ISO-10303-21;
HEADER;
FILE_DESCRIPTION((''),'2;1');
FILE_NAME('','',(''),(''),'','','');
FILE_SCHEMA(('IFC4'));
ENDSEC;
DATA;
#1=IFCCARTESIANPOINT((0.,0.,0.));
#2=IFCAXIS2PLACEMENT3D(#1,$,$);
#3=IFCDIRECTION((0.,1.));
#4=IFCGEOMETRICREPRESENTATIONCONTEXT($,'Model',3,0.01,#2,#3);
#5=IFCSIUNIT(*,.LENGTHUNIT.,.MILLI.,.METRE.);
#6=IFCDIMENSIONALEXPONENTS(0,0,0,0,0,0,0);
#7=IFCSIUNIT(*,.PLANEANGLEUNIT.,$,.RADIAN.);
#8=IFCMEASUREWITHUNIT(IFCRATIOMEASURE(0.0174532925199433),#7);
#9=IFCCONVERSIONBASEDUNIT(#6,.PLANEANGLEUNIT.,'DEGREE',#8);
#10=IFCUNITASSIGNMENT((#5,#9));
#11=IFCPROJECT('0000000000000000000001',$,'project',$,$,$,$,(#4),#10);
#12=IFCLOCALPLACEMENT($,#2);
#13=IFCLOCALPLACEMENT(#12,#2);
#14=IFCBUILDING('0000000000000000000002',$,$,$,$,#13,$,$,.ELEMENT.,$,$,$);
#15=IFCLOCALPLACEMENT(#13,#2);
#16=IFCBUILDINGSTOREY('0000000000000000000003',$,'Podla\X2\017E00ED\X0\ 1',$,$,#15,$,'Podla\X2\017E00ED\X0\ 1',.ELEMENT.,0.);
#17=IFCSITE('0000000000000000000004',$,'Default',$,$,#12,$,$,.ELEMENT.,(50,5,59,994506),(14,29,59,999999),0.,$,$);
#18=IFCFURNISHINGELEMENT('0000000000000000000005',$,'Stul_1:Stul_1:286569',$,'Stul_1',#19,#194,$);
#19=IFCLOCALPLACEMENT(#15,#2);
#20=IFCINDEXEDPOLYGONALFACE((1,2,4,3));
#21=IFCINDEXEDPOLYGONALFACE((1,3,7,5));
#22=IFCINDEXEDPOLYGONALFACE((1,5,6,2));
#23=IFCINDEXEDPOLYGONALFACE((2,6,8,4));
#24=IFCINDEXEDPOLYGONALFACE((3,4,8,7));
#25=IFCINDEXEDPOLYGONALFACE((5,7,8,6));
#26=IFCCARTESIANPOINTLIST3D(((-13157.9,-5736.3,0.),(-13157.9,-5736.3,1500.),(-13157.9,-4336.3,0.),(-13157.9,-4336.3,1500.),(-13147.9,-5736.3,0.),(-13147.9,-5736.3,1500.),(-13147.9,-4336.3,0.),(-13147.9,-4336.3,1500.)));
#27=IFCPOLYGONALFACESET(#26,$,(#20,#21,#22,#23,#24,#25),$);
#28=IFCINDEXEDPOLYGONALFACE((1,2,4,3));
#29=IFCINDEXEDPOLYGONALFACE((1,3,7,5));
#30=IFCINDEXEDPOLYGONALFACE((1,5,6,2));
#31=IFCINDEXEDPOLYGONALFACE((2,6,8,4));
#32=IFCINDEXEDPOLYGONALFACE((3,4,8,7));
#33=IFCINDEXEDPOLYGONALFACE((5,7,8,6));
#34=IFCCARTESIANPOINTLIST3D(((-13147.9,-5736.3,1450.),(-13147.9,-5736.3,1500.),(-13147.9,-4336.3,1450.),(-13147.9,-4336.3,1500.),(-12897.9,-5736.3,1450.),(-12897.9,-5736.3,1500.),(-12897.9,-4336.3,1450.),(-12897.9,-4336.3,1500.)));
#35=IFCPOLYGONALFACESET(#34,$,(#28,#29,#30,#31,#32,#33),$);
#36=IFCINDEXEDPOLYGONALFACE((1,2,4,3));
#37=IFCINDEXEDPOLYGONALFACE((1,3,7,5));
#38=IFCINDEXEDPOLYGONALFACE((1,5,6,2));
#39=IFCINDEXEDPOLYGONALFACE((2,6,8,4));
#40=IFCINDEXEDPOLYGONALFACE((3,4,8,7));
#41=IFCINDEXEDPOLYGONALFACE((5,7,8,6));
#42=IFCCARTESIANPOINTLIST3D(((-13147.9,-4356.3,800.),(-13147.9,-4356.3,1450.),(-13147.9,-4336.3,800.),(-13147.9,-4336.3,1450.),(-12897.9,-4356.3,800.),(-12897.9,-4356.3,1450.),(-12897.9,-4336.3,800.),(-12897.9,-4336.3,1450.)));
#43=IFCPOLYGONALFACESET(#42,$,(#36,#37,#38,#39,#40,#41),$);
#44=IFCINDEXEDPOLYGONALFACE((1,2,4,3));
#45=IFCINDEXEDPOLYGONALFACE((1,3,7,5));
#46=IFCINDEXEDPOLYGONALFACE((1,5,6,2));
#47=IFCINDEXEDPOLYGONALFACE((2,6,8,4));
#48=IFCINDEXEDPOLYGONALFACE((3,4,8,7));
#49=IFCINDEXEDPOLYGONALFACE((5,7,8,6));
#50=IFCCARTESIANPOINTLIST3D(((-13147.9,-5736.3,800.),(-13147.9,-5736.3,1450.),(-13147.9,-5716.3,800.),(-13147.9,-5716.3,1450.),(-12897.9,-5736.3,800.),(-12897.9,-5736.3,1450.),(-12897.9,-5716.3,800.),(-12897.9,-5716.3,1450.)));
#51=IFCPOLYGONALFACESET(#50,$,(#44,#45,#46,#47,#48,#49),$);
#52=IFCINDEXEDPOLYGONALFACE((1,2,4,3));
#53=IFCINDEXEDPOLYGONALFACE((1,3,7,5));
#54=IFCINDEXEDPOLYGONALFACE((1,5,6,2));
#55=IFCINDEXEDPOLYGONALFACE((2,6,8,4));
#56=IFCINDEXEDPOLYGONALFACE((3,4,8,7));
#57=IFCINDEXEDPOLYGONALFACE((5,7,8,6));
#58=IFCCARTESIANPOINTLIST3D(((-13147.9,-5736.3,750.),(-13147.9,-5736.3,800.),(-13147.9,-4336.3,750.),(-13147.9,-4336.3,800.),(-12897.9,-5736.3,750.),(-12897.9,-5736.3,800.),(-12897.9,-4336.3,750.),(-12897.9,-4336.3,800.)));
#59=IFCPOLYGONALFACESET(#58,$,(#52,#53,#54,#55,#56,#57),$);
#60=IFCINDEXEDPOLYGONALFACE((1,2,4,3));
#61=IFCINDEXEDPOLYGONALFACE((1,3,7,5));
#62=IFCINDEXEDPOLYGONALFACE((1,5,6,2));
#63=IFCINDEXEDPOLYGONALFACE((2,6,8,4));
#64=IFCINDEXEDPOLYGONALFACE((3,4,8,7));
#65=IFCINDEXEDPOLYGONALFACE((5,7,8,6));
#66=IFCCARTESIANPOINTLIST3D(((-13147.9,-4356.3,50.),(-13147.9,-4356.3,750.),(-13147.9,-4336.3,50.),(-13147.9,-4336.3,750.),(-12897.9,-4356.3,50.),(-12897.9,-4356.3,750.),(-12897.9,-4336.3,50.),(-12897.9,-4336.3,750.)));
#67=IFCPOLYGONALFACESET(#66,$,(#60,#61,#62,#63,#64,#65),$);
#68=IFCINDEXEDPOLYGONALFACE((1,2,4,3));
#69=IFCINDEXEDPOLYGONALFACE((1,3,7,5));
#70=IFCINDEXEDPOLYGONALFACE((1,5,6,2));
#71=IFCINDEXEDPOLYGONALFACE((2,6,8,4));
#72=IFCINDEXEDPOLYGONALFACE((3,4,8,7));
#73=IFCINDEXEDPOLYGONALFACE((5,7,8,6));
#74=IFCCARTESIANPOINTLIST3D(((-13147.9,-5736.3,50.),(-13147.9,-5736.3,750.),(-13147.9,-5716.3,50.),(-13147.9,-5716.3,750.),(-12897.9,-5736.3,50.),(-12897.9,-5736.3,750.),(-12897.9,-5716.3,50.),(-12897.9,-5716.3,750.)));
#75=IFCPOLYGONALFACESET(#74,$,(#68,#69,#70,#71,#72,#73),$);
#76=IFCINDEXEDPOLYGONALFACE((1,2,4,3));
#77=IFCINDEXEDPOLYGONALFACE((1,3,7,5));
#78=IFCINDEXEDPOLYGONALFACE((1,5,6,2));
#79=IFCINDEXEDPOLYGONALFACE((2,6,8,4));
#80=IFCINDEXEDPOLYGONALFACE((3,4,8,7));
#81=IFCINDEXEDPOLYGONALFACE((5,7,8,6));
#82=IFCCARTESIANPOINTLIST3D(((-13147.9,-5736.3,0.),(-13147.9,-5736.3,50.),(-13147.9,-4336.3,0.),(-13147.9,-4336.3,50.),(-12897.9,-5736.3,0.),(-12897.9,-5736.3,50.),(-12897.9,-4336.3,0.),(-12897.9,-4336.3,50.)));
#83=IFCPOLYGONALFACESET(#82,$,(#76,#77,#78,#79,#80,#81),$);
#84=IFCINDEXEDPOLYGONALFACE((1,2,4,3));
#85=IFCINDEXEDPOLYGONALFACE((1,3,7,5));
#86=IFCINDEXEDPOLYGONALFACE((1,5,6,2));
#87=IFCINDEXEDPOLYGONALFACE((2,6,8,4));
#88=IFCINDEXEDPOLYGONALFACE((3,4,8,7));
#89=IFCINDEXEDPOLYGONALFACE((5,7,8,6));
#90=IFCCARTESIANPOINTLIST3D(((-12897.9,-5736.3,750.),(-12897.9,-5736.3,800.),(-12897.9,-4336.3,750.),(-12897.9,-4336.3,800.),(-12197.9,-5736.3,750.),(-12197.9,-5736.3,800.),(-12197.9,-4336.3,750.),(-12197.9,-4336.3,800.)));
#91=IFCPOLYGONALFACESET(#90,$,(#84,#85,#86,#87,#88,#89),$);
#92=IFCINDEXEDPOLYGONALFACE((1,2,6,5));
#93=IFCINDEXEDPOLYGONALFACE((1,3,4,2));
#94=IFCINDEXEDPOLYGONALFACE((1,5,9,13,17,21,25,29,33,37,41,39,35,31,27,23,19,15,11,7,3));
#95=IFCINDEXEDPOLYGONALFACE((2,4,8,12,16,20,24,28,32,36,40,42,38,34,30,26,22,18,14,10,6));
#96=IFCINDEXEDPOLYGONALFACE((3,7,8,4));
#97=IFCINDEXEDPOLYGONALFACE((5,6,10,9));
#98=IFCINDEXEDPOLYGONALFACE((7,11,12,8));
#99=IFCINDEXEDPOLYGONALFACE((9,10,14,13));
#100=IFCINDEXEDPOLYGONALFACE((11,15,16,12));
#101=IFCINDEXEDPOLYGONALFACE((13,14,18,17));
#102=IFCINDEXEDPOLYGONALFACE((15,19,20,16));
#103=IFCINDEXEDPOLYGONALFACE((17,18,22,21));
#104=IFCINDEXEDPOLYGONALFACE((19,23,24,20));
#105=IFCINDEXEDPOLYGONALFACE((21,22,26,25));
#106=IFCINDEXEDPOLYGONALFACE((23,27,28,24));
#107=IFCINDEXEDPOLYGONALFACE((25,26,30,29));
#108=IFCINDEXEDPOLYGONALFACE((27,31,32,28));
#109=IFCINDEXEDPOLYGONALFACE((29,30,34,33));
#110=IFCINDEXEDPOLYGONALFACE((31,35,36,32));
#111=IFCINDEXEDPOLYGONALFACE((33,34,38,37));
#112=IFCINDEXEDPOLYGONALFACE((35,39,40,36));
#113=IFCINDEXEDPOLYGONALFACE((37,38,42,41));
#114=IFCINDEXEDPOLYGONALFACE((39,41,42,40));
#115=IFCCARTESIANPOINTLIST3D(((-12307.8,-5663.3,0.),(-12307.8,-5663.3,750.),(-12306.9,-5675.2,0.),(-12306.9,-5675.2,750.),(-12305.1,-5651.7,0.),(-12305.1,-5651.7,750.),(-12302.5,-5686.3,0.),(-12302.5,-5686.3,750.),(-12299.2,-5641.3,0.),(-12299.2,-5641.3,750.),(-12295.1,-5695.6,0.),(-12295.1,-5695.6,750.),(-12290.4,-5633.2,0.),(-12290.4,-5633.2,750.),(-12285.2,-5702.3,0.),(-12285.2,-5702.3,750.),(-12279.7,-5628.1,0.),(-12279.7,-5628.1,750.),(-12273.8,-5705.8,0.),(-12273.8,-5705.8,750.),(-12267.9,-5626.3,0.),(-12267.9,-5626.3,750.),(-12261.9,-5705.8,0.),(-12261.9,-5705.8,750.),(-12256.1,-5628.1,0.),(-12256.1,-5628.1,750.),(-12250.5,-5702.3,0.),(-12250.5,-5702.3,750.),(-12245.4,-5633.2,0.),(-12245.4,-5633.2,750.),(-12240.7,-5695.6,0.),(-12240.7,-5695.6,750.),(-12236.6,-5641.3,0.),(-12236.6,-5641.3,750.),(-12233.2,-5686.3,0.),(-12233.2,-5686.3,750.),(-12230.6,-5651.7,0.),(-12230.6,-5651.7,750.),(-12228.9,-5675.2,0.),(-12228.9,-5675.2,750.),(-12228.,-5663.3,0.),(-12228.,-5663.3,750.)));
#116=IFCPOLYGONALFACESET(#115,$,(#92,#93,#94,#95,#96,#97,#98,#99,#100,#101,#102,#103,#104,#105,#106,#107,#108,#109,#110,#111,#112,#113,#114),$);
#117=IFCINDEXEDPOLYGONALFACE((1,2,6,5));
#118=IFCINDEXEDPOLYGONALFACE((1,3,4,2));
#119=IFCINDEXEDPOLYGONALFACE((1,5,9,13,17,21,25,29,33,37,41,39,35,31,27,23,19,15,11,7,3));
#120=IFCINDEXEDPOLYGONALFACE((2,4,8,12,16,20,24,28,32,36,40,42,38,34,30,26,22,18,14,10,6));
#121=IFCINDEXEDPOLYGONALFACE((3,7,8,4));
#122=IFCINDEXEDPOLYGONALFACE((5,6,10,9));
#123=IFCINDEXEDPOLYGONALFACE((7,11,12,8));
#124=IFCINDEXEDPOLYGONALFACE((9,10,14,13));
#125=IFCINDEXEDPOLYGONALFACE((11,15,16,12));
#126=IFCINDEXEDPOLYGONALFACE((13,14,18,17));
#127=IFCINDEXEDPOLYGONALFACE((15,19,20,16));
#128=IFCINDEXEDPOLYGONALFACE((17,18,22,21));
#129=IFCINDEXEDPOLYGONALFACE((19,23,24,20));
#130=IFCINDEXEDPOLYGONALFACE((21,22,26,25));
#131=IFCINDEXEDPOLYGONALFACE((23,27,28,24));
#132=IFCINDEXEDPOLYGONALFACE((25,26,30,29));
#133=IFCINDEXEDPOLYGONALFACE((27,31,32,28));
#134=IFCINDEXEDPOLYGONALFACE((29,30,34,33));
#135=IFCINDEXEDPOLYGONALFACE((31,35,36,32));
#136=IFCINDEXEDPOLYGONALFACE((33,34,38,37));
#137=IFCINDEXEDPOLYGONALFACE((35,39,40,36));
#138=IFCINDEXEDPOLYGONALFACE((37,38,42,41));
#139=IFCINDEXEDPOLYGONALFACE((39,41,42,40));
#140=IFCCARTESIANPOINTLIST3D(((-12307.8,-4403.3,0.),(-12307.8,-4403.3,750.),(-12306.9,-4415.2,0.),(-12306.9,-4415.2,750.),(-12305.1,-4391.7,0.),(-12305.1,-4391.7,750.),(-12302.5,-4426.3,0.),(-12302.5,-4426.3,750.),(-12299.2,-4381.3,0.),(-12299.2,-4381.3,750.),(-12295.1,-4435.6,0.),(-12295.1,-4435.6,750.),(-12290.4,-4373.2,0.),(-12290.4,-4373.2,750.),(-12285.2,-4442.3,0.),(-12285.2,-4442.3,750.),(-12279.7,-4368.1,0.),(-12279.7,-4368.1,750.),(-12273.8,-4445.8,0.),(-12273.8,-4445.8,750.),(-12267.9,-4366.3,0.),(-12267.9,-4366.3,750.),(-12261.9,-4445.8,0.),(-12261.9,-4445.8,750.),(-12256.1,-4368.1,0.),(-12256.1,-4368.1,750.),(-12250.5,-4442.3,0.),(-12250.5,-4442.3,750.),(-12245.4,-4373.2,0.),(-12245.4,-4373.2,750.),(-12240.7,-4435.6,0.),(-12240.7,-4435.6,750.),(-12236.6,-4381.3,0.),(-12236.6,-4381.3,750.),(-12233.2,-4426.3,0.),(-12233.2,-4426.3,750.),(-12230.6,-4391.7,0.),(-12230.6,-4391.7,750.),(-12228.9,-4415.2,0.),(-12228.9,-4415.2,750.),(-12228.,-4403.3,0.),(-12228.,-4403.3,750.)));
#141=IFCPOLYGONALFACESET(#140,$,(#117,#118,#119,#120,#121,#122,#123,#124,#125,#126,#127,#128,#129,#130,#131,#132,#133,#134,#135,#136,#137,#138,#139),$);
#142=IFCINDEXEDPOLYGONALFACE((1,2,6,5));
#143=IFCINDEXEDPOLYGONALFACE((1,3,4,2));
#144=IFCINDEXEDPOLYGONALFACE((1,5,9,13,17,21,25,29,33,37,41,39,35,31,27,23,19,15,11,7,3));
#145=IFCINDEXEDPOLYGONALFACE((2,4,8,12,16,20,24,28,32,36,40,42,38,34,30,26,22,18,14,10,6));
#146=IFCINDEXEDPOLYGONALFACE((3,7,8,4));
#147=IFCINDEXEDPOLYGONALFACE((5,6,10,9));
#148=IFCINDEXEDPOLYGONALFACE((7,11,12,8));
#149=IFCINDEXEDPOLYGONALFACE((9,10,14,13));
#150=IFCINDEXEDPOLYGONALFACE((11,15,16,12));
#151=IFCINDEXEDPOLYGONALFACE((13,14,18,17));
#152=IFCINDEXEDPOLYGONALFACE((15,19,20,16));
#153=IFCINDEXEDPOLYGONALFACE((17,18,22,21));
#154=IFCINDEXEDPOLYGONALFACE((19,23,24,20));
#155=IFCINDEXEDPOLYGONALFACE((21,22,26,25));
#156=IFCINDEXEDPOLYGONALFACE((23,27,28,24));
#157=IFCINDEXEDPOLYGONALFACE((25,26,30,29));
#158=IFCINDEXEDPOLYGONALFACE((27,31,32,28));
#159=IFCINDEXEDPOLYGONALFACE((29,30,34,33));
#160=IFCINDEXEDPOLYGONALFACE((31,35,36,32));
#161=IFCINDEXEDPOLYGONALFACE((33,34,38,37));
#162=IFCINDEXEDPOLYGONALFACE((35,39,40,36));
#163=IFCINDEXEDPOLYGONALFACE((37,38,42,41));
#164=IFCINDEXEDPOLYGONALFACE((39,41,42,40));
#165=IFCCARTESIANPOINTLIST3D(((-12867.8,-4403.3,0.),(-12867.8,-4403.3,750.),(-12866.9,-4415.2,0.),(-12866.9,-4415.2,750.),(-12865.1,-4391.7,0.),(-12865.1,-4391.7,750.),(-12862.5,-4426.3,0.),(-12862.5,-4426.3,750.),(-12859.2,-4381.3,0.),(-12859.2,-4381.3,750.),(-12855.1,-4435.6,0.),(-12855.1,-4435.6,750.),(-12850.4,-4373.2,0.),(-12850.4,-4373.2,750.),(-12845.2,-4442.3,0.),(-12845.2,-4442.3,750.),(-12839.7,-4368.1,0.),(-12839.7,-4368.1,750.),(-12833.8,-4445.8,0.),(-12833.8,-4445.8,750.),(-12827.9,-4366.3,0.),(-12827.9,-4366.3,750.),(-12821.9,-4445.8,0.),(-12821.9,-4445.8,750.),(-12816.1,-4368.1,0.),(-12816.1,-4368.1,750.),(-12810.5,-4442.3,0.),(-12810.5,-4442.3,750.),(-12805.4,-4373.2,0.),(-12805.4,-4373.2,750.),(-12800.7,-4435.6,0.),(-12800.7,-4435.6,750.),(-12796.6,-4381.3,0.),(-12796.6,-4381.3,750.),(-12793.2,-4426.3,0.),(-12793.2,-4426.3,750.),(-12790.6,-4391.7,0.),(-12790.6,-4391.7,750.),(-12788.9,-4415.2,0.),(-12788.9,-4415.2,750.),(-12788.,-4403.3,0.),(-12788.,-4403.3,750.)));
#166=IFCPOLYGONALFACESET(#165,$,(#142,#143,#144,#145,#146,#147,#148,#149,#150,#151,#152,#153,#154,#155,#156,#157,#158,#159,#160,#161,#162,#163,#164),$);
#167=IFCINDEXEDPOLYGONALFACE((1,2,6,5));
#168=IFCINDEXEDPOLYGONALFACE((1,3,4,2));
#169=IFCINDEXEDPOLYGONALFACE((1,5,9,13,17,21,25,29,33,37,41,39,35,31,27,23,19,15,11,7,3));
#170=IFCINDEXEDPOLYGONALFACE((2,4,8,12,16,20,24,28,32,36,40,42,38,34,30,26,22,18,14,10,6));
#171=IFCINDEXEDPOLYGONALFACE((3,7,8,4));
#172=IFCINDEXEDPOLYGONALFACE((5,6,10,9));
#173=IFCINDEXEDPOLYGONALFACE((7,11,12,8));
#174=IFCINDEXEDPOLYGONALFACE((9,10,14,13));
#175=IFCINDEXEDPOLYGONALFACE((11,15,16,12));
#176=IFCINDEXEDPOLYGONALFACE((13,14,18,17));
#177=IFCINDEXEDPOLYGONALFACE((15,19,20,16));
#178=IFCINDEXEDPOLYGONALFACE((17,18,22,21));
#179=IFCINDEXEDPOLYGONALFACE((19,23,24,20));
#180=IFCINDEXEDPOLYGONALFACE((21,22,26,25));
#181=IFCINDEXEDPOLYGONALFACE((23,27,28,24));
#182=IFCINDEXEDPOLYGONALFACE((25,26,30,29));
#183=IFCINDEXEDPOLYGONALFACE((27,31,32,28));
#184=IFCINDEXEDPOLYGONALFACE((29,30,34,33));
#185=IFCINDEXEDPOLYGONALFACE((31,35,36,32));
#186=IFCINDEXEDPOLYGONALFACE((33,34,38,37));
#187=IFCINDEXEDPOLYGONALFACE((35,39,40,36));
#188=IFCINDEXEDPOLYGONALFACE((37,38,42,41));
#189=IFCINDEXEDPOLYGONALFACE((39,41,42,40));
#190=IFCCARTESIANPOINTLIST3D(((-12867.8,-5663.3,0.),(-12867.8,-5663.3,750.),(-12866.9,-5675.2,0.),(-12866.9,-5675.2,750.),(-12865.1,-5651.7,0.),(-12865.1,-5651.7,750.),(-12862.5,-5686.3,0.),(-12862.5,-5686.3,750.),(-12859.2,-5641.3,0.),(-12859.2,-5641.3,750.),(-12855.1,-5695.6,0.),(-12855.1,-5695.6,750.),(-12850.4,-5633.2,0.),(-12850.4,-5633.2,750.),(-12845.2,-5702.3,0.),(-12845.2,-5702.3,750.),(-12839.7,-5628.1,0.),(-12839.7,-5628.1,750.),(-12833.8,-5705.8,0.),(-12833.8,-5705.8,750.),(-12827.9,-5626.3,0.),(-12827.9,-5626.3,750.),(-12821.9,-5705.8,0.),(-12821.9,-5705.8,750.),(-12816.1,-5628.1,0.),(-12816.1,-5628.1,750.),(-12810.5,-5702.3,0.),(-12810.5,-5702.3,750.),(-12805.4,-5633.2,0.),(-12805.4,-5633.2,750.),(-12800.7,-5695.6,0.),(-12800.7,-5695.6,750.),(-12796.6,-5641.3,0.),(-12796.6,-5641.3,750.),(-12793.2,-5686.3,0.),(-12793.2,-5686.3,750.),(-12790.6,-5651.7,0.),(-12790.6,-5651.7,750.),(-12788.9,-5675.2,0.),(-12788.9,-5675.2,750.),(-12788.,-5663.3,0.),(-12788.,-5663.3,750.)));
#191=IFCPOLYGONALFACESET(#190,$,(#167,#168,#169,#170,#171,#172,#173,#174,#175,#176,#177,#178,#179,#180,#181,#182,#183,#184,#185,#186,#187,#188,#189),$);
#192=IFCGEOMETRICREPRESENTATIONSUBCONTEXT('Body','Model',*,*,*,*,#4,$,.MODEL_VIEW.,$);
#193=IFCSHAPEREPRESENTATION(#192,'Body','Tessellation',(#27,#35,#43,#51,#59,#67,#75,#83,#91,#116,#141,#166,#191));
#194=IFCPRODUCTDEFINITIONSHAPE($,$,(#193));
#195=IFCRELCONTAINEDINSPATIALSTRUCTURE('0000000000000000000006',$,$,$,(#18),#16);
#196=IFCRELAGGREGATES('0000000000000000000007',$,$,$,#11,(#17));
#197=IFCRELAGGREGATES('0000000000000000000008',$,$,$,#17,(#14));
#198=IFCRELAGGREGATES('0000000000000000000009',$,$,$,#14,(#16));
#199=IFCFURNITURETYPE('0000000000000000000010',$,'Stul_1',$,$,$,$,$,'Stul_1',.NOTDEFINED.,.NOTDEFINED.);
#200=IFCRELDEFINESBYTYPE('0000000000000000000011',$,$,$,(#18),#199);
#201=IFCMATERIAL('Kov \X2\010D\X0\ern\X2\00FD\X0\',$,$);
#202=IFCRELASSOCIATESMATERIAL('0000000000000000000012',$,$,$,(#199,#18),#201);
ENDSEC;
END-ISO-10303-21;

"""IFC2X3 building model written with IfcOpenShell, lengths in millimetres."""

from ifc_helpers import new_model, entity, si_unit, converted_unit, direction, frame, frame_2d, origin, origin_2d_with_axis, place, context, subcontext, project, spatial, rectangle, circle, extrude, source, transform, mapped, material, type_object, type_shapes, element, save


model = new_model("IFC2X3")

# Units and contexts
model_context = context("Model", 3, precision=0.01, world=origin(), true_north=direction((0.0, 1.0)))
body_context = subcontext(model_context, "Body", "Model", "MODEL_VIEW")
ifc_project = project(units=[si_unit("LENGTHUNIT", "METRE", prefix="MILLI"), converted_unit("PLANEANGLEUNIT", "DEGREE", entity("IfcRatioMeasure", 0.0174532925199433), si_unit("PLANEANGLEUNIT", "RADIAN"), dimensions=[0, 0, 0, 0, 0, 0, 0])], contexts=[model_context])

# Site, building, storey
site_placement = place(None, origin())
site = spatial("IfcSite", under=ifc_project, at=site_placement, Name="Default", CompositionType="ELEMENT", RefLatitude=(50, 5, 59, 994506), RefLongitude=(14, 29, 59, 999999), RefElevation=0.0)
building_placement = place(site_placement, origin())
building = spatial("IfcBuilding", under=site, at=building_placement, CompositionType="ELEMENT")
storey_placement = place(building_placement, origin())
storey = spatial("IfcBuildingStorey", under=building, at=storey_placement, Name="Podlaží 1", LongName="Podlaží 1", CompositionType="ELEMENT", Elevation=0.0)

# Furnishing element
ifc_material_1 = material(Name="Kov černý")
furniture_type = type_object("IfcFurnitureType", Name="Stul_1", ElementType="Stul_1", material=ifc_material_1)
shared_shape_1 = source(origin(), body_context, "Body", "SweptSolid", [
    extrude(rectangle(XDim=1400.0, YDim=10.0, at=origin_2d_with_axis()), frame((0.0, 605.0, 0.0), z_axis=(0.0, 0.0, 1.0), x_axis=(-1.0, 0.0, 0.0)), (0.0, 0.0, 1.0), 1500.0),
    extrude(rectangle(XDim=1400.0, YDim=250.0, at=frame_2d((0.0, 0.0), x_axis=(1.0, 0.0))), frame((0.0, 475.0, 1450.0), z_axis=(0.0, 0.0, 1.0), x_axis=(-1.0, 0.0, 0.0)), (0.0, 0.0, 1.0), 50.0),
    extrude(rectangle(XDim=20.0, YDim=250.0, at=origin_2d_with_axis()), frame((690.0, 475.0, 800.0), z_axis=(0.0, 0.0, 1.0), x_axis=(-1.0, 0.0, 0.0)), (0.0, 0.0, 1.0), 650.0),
    extrude(rectangle(XDim=20.0, YDim=250.0, at=frame_2d((0.0, 0.0), x_axis=(1.0, 0.0))), frame((-690.0, 475.0, 800.0), z_axis=(0.0, 0.0, 1.0), x_axis=(-1.0, 0.0, 0.0)), (0.0, 0.0, 1.0), 650.0),
    extrude(rectangle(XDim=1400.0, YDim=250.0, at=origin_2d_with_axis()), frame((0.0, 475.0, 750.0), z_axis=(0.0, 0.0, 1.0), x_axis=(-1.0, 0.0, 0.0)), (0.0, 0.0, 1.0), 50.0),
    extrude(rectangle(XDim=20.0, YDim=250.0, at=origin_2d_with_axis()), frame((690.0, 475.0, 50.0), z_axis=(0.0, 0.0, 1.0), x_axis=(-1.0, 0.0, 0.0)), (0.0, 0.0, 1.0), 700.0),
    extrude(rectangle(XDim=20.0, YDim=250.0, at=frame_2d((0.0, 0.0), x_axis=(1.0, 0.0))), frame((-690.0, 475.0, 50.0), z_axis=(0.0, 0.0, 1.0), x_axis=(-1.0, 0.0, 0.0)), (0.0, 0.0, 1.0), 700.0),
    extrude(rectangle(XDim=1400.0, YDim=250.0, at=origin_2d_with_axis()), frame((0.0, 475.0, 0.0), z_axis=(0.0, 0.0, 1.0), x_axis=(-1.0, 0.0, 0.0)), (0.0, 0.0, 1.0), 50.0),
    extrude(rectangle(XDim=1400.0, YDim=700.0, at=origin_2d_with_axis()), frame((0.0, 0.0, 750.0), z_axis=(0.0, 0.0, 1.0), x_axis=(-1.0, 0.0, 0.0)), (0.0, 0.0, 1.0), 50.0),
    extrude(circle(Radius=40.0, at=frame_2d((0.0, 0.0), x_axis=(1.0, 0.0))), frame((-630.0, -280.0, 0.0)), (0.0, 0.0, 1.0), 750.0),
    extrude(circle(Radius=40.0, at=frame_2d((0.0, 0.0), x_axis=(1.0, 0.0))), frame((630.0, -280.0, 0.0)), (0.0, 0.0, 1.0), 750.0),
    extrude(circle(Radius=40.0, at=frame_2d((0.0, 0.0), x_axis=(1.0, 0.0))), frame((630.0, 280.0, 0.0)), (0.0, 0.0, 1.0), 750.0),
    extrude(circle(Radius=40.0, at=frame_2d((0.0, 0.0), x_axis=(1.0, 0.0))), frame((-630.0, 280.0, 0.0)), (0.0, 0.0, 1.0), 750.0),
])
type_shapes(furniture_type, [shared_shape_1])
for number, where, z_axis, x_axis, name in (
    (1, (-12547.9, -5036.3, 0.0), (0.0, 0.0, 1.0), (0.0, 1.0, 0.0), "Stul_1:Stul_1:286569"),
):
    element("IfcFurnishingElement", number, at=place(storey_placement, frame(where, z_axis=z_axis, x_axis=x_axis)), inside=storey, type_object=furniture_type, material=ifc_material_1, Name=name, ObjectType="Stul_1", context=body_context, shape_type="MappedRepresentation", body=[
        mapped(shared_shape_1, transform((0.0, 0.0, 0.0), scale=1.0)),
    ])

save(model, "model.ifc")
